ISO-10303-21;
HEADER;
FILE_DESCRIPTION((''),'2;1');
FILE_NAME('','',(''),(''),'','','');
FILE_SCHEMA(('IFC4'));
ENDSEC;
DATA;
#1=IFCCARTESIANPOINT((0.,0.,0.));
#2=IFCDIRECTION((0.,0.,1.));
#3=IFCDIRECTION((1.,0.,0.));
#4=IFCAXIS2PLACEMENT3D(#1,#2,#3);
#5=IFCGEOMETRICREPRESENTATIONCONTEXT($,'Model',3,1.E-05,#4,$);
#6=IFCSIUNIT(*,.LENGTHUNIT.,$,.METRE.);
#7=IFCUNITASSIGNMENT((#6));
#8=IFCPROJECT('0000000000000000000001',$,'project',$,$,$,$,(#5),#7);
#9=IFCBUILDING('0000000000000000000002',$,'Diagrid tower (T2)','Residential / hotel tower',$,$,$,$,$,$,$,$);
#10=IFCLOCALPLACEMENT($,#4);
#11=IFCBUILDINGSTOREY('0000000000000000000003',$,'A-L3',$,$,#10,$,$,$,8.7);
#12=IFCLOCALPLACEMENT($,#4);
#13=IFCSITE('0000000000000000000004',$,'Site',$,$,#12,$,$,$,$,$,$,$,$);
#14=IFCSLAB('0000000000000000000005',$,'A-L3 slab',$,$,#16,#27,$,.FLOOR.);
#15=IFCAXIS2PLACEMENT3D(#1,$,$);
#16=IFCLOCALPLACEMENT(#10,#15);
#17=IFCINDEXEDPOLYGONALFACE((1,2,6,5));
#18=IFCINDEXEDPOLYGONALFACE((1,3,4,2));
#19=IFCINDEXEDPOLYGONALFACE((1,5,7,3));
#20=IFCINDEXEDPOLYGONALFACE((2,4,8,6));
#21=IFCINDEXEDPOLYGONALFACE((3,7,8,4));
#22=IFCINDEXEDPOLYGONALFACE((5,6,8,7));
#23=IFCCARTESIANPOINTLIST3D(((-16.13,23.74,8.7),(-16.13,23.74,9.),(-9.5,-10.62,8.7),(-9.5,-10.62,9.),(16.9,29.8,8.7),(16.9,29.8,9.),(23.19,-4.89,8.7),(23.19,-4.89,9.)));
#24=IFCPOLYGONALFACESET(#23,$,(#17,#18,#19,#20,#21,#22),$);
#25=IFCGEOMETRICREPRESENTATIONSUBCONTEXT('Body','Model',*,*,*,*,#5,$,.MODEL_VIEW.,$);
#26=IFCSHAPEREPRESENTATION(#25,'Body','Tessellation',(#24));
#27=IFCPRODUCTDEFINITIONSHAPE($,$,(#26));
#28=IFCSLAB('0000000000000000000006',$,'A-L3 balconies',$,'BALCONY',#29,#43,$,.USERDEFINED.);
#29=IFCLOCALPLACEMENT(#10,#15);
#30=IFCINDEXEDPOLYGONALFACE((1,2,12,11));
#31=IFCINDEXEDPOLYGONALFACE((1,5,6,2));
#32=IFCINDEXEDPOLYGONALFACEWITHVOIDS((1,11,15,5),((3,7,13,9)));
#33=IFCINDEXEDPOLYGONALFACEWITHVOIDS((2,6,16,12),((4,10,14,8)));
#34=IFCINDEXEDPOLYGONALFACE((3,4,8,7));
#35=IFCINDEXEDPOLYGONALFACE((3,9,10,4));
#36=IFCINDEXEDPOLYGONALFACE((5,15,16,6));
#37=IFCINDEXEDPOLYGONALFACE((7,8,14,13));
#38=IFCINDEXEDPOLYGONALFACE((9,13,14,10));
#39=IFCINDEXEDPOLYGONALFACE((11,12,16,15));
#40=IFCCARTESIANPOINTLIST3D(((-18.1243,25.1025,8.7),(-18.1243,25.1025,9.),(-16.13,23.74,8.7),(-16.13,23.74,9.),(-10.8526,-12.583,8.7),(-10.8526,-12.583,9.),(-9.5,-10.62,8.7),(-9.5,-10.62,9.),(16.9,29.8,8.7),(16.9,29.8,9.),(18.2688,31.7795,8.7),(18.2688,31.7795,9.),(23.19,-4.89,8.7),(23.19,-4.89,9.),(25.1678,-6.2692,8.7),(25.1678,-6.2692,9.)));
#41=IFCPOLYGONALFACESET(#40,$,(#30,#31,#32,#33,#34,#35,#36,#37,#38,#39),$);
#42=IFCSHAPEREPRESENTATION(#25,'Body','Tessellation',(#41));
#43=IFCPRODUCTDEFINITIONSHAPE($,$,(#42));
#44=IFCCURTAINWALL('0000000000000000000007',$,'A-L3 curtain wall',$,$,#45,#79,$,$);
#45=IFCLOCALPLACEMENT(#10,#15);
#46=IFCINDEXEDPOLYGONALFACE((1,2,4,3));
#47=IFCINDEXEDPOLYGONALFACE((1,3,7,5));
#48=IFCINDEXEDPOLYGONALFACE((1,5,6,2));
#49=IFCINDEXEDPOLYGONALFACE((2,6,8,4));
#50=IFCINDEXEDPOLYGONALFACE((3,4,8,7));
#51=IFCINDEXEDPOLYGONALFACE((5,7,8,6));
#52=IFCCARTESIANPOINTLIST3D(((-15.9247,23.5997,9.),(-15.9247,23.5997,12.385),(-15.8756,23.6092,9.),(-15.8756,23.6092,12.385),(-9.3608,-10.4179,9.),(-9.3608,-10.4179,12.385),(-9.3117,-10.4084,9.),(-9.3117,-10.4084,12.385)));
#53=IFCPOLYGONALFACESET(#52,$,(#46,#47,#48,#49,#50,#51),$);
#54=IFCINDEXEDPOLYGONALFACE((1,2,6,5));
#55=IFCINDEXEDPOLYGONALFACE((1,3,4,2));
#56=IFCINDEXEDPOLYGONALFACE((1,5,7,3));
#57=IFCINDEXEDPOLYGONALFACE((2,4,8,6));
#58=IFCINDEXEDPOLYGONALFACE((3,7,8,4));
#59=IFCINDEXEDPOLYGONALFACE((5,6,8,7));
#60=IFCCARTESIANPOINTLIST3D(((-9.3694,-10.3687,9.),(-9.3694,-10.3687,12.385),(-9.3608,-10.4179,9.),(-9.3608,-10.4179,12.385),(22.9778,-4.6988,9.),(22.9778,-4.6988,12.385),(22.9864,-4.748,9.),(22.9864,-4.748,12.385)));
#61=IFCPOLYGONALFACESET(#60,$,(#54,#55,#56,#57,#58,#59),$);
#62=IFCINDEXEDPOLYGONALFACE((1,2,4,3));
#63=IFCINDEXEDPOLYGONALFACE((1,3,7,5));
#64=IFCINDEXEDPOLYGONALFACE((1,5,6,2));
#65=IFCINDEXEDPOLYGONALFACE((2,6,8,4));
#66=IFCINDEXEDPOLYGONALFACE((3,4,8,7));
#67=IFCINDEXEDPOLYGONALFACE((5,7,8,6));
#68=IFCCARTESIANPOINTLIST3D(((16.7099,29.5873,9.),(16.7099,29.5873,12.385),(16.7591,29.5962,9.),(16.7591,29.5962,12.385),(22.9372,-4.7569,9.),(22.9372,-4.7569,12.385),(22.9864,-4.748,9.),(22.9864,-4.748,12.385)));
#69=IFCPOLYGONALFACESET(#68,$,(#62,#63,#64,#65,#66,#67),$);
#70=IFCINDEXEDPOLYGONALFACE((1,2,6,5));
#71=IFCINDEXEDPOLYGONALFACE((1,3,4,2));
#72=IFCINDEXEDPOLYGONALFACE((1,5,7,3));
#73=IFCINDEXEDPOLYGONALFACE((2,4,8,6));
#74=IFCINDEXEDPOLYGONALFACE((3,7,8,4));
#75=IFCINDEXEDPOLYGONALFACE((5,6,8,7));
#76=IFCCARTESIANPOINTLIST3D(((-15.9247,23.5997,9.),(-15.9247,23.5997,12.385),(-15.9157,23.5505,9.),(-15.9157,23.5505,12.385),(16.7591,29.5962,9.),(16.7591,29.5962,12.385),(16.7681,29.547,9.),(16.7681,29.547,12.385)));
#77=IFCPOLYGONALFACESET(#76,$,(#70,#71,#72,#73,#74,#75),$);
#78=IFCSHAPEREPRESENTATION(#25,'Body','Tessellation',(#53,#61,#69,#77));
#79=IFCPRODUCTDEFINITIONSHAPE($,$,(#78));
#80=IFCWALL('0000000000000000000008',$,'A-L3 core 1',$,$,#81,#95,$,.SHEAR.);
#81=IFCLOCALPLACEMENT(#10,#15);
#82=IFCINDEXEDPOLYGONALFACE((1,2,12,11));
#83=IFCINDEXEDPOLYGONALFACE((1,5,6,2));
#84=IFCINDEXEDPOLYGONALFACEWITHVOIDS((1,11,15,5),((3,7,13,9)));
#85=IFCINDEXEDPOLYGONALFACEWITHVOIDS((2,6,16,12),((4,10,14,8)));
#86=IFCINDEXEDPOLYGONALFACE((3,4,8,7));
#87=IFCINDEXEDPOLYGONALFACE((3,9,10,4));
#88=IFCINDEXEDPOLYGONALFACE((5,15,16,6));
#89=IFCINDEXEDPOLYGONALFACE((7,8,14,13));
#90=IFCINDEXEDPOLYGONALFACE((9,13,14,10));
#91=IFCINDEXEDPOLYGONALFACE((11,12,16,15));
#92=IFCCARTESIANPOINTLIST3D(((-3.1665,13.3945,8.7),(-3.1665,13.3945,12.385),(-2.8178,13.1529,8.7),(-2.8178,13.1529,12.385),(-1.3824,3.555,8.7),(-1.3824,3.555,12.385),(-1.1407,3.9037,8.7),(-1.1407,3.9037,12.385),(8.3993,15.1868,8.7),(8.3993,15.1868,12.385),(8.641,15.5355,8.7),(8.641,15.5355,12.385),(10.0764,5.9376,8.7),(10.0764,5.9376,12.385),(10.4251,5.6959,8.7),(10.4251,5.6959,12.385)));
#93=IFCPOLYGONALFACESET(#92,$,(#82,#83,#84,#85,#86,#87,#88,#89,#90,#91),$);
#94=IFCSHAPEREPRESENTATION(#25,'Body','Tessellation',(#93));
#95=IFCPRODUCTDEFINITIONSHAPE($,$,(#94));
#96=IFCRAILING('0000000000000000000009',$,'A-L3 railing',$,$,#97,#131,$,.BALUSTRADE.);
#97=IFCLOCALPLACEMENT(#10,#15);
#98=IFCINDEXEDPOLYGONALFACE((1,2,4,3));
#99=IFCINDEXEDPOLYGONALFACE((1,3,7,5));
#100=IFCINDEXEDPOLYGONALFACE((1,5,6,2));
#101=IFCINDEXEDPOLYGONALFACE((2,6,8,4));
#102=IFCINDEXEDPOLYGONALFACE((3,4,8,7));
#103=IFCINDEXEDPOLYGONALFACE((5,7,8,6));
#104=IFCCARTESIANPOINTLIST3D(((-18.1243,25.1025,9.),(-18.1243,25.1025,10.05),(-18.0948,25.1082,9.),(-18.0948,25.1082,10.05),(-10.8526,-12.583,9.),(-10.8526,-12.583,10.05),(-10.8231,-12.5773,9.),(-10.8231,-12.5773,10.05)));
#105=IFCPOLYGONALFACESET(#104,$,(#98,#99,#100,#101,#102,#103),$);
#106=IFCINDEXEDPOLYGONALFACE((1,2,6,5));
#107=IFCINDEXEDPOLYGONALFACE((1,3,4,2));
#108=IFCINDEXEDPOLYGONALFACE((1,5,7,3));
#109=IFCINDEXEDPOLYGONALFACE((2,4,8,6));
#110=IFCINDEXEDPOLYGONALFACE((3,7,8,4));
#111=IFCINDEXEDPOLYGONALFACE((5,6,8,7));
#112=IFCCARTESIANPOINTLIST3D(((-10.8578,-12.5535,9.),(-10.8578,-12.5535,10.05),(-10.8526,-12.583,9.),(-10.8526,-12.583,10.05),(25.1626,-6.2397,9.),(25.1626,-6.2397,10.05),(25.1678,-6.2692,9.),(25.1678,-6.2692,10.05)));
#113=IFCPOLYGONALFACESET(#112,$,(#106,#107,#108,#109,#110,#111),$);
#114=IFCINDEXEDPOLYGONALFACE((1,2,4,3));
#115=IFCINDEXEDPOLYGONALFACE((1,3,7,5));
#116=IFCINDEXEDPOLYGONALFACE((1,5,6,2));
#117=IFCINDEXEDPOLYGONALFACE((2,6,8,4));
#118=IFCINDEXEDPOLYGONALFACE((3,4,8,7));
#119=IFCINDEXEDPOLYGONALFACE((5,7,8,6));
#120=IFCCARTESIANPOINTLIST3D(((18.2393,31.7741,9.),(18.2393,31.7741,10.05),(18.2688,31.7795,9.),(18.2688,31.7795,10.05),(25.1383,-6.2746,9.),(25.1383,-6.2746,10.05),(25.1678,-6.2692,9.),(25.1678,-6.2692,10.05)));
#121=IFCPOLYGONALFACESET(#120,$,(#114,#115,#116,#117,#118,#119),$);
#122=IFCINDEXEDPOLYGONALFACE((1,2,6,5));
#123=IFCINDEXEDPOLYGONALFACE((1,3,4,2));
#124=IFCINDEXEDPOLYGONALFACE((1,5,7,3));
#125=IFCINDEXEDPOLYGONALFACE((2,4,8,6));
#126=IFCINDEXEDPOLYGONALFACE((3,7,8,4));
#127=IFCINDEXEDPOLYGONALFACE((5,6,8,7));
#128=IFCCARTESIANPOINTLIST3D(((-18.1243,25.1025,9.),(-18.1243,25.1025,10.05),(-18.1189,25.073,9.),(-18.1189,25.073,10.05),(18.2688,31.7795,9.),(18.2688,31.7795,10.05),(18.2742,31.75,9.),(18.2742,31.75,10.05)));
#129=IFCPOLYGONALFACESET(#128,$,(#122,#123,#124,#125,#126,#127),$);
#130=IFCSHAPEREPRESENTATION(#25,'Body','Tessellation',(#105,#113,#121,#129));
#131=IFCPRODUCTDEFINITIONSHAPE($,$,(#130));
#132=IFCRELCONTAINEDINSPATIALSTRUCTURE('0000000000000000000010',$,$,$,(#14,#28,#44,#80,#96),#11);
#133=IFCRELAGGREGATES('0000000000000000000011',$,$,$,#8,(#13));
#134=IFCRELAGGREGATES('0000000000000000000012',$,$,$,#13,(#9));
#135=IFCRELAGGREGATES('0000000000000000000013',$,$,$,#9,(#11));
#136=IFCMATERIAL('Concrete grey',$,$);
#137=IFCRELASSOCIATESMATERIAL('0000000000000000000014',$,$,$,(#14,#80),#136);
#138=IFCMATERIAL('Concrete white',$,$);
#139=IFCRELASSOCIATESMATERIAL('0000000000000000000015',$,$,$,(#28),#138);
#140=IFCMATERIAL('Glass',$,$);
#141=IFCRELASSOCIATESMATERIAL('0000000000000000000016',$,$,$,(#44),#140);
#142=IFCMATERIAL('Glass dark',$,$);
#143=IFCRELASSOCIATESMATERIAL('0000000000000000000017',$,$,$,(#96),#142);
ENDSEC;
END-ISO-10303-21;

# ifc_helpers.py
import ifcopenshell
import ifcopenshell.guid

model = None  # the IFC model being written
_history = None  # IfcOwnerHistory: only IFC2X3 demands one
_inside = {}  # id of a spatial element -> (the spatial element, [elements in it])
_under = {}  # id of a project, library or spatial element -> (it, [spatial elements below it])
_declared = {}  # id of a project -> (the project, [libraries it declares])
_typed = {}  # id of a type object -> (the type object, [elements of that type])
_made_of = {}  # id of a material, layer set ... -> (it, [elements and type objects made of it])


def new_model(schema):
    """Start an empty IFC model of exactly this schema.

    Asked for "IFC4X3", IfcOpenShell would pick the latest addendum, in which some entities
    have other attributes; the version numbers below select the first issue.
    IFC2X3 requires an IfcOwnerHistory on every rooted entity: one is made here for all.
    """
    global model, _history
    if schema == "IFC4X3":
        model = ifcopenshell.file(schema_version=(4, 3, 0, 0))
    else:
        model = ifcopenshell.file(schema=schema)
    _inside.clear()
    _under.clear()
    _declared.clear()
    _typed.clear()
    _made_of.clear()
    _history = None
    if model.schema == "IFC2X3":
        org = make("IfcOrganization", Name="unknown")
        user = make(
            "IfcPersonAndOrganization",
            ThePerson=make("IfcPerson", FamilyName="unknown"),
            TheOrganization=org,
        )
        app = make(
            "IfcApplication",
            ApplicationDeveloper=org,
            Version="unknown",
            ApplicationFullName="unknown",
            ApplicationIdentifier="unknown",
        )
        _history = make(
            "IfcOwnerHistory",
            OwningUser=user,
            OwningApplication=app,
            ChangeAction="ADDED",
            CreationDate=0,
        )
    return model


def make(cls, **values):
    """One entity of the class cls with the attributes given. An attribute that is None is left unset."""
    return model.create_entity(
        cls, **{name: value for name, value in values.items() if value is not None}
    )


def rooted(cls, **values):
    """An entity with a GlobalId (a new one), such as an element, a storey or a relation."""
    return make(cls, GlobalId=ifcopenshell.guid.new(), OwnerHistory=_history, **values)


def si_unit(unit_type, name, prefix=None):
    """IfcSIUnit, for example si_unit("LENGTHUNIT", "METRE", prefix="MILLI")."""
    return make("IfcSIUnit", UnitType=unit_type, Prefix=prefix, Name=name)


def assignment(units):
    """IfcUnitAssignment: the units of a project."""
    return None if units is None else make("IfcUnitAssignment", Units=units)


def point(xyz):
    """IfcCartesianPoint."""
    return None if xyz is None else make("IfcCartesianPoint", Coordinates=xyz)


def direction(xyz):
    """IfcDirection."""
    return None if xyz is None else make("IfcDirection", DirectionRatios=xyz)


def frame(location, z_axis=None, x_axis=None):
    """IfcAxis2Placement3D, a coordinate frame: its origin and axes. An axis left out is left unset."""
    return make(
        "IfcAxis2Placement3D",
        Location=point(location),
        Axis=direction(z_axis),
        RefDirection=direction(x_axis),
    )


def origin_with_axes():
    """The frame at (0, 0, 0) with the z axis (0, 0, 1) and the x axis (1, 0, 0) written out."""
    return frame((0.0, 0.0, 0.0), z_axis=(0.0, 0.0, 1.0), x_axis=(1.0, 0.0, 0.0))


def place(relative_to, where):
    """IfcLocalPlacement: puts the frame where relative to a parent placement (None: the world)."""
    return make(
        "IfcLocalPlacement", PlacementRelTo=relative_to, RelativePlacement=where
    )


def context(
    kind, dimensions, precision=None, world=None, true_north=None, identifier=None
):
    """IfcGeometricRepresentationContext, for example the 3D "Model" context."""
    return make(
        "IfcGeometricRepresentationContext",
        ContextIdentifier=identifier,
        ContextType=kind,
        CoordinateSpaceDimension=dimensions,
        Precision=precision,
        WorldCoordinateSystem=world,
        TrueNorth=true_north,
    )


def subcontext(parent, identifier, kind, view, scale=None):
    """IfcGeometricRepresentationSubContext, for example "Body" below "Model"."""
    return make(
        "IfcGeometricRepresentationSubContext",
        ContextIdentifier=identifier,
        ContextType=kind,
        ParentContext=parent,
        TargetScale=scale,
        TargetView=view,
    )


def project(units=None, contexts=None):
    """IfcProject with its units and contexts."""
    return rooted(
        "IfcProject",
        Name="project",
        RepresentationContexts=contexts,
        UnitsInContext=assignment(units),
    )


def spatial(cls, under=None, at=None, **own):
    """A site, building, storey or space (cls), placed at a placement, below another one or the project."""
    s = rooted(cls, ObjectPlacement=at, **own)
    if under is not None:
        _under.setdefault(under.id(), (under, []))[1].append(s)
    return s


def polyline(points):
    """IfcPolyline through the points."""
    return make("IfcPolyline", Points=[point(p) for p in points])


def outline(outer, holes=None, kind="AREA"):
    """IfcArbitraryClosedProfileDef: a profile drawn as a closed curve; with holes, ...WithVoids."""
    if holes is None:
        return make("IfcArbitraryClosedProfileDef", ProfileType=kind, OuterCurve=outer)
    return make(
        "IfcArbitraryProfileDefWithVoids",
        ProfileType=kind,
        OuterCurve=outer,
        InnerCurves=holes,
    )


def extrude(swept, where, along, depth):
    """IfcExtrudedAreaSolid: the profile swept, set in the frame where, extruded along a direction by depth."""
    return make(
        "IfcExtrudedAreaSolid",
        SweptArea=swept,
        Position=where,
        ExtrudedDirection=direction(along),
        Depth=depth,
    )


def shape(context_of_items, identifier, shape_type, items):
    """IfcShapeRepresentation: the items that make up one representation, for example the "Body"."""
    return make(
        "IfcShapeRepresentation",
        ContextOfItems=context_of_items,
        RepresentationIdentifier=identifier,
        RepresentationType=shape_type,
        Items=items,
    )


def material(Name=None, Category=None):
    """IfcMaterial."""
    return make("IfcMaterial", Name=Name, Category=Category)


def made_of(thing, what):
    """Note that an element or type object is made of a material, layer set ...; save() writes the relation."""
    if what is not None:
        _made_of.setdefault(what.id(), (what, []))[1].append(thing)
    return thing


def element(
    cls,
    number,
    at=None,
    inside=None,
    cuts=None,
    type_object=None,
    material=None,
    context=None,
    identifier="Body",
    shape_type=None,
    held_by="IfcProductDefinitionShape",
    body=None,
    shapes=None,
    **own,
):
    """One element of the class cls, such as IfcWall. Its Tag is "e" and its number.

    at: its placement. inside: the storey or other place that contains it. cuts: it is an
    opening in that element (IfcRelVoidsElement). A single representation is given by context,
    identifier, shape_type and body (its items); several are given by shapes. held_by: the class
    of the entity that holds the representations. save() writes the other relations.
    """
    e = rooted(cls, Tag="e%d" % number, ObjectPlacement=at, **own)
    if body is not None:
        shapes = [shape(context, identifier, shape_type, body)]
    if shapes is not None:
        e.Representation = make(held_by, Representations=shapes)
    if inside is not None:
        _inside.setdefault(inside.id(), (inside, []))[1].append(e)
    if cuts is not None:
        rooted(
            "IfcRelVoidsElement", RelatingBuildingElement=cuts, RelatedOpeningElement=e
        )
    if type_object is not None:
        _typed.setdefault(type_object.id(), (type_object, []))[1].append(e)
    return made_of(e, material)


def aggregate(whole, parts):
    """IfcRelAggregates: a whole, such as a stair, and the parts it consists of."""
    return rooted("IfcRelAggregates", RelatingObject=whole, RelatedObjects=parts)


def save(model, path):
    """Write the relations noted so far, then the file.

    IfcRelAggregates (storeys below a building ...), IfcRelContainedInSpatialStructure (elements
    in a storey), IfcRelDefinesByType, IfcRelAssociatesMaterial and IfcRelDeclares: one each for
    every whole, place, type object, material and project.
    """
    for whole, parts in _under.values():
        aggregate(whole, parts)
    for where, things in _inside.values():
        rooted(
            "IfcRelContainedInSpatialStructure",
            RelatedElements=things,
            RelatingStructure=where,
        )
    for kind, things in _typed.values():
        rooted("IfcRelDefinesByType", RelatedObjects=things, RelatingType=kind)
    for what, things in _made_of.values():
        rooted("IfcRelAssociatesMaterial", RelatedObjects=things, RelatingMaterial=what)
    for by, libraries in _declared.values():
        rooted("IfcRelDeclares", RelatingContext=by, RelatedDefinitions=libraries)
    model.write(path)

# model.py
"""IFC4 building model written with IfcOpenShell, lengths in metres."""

from ifc_helpers import new_model, si_unit, frame, origin_with_axes, place, context, subcontext, project, spatial, polyline, outline, extrude, material, element, save


model = new_model("IFC4")

# Units and contexts
model_context = context("Model", 3, precision=1e-05, world=origin_with_axes())
body_context = subcontext(model_context, "Body", "Model", "MODEL_VIEW")
ifc_project = project(units=[si_unit("LENGTHUNIT", "METRE")], contexts=[model_context])

# Site, building, storey
site_placement = place(None, origin_with_axes())
site = spatial("IfcSite", under=ifc_project, at=site_placement, Name="Site")
building = spatial("IfcBuilding", under=site, Name="Diagrid tower (T2)", Description="Residential / hotel tower")
storey_placement = place(None, origin_with_axes())
storey = spatial("IfcBuildingStorey", under=building, at=storey_placement, Name="A-L3", Elevation=8.7)

# Slabs
ifc_material_1 = material(Name="Concrete grey")
slab_1_placement = place(storey_placement, origin_with_axes())
element("IfcSlab", 1, at=slab_1_placement, inside=storey, material=ifc_material_1, Name="A-L3 slab", PredefinedType="FLOOR", context=body_context, shape_type="SweptSolid", body=[
    extrude(outline(polyline([(-16.13, 23.74), (-9.5, -10.62), (23.19, -4.89), (16.9, 29.8), (-16.13, 23.74)])), frame((0.0, 0.0, 8.7), z_axis=(0.0, 0.0, 1.0), x_axis=(1.0, 0.0, 0.0)), (0.0, 0.0, 1.0), 0.3),
])
ifc_material_2 = material(Name="Concrete white")
slab_2_placement = place(storey_placement, origin_with_axes())
element("IfcSlab", 2, at=slab_2_placement, inside=storey, material=ifc_material_2, Name="A-L3 balconies", ObjectType="BALCONY", PredefinedType="USERDEFINED", context=body_context, shape_type="SweptSolid", body=[
    extrude(outline(polyline([(-18.1243, 25.1025), (-10.8526, -12.583), (25.1678, -6.2692), (18.2688, 31.7795), (-18.1243, 25.1025)]), holes=[polyline([(-16.13, 23.74), (-9.5, -10.62), (23.19, -4.89), (16.9, 29.8), (-16.13, 23.74)])]), frame((0.0, 0.0, 8.7), z_axis=(0.0, 0.0, 1.0), x_axis=(1.0, 0.0, 0.0)), (0.0, 0.0, 1.0), 0.3),
])

# Curtain wall
ifc_material_3 = material(Name="Glass")
curtain_wall_placement = place(storey_placement, origin_with_axes())
element("IfcCurtainWall", 3, at=curtain_wall_placement, inside=storey, material=ifc_material_3, Name="A-L3 curtain wall", context=body_context, shape_type="SweptSolid", body=[
    extrude(outline(polyline([(-15.9247, 23.5997), (-9.3608, -10.4179), (-9.3117, -10.4084), (-15.8756, 23.6092), (-15.9247, 23.5997)])), frame((0.0, 0.0, 9.0), z_axis=(0.0, 0.0, 1.0), x_axis=(1.0, 0.0, 0.0)), (0.0, 0.0, 1.0), 3.385),
    extrude(outline(polyline([(-9.3608, -10.4179), (22.9864, -4.748), (22.9778, -4.6988), (-9.3694, -10.3687), (-9.3608, -10.4179)])), frame((0.0, 0.0, 9.0), z_axis=(0.0, 0.0, 1.0), x_axis=(1.0, 0.0, 0.0)), (0.0, 0.0, 1.0), 3.385),
    extrude(outline(polyline([(22.9864, -4.748), (16.7591, 29.5962), (16.7099, 29.5873), (22.9372, -4.7569), (22.9864, -4.748)])), frame((0.0, 0.0, 9.0), z_axis=(0.0, 0.0, 1.0), x_axis=(1.0, 0.0, 0.0)), (0.0, 0.0, 1.0), 3.385),
    extrude(outline(polyline([(16.7591, 29.5962), (-15.9247, 23.5997), (-15.9157, 23.5505), (16.7681, 29.547), (16.7591, 29.5962)])), frame((0.0, 0.0, 9.0), z_axis=(0.0, 0.0, 1.0), x_axis=(1.0, 0.0, 0.0)), (0.0, 0.0, 1.0), 3.385),
])

# Wall
wall_placement = place(storey_placement, origin_with_axes())
element("IfcWall", 4, at=wall_placement, inside=storey, material=ifc_material_1, Name="A-L3 core 1", PredefinedType="SHEAR", context=body_context, shape_type="SweptSolid", body=[
    extrude(outline(polyline([(10.4251, 5.6959), (8.641, 15.5355), (-3.1665, 13.3945), (-1.3824, 3.555), (10.4251, 5.6959)]), holes=[polyline([(10.0764, 5.9376), (8.3993, 15.1868), (-2.8178, 13.1529), (-1.1407, 3.9037), (10.0764, 5.9376)])]), frame((0.0, 0.0, 8.7), z_axis=(0.0, 0.0, 1.0), x_axis=(1.0, 0.0, 0.0)), (0.0, 0.0, 1.0), 3.685),
])

# Railing
ifc_material_4 = material(Name="Glass dark")
railing_placement = place(storey_placement, origin_with_axes())
element("IfcRailing", 5, at=railing_placement, inside=storey, material=ifc_material_4, Name="A-L3 railing", PredefinedType="BALUSTRADE", context=body_context, shape_type="SweptSolid", body=[
    extrude(outline(polyline([(-18.1243, 25.1025), (-10.8526, -12.583), (-10.8231, -12.5773), (-18.0948, 25.1082), (-18.1243, 25.1025)])), frame((0.0, 0.0, 9.0), z_axis=(0.0, 0.0, 1.0), x_axis=(1.0, 0.0, 0.0)), (0.0, 0.0, 1.0), 1.05),
    extrude(outline(polyline([(-10.8526, -12.583), (25.1678, -6.2692), (25.1626, -6.2397), (-10.8578, -12.5535), (-10.8526, -12.583)])), frame((0.0, 0.0, 9.0), z_axis=(0.0, 0.0, 1.0), x_axis=(1.0, 0.0, 0.0)), (0.0, 0.0, 1.0), 1.05),
    extrude(outline(polyline([(25.1678, -6.2692), (18.2688, 31.7795), (18.2393, 31.7741), (25.1383, -6.2746), (25.1678, -6.2692)])), frame((0.0, 0.0, 9.0), z_axis=(0.0, 0.0, 1.0), x_axis=(1.0, 0.0, 0.0)), (0.0, 0.0, 1.0), 1.05),
    extrude(outline(polyline([(18.2688, 31.7795), (-18.1243, 25.1025), (-18.1189, 25.073), (18.2742, 31.75), (18.2688, 31.7795)])), frame((0.0, 0.0, 9.0), z_axis=(0.0, 0.0, 1.0), x_axis=(1.0, 0.0, 0.0)), (0.0, 0.0, 1.0), 1.05),
])

save(model, "model.ifc")
